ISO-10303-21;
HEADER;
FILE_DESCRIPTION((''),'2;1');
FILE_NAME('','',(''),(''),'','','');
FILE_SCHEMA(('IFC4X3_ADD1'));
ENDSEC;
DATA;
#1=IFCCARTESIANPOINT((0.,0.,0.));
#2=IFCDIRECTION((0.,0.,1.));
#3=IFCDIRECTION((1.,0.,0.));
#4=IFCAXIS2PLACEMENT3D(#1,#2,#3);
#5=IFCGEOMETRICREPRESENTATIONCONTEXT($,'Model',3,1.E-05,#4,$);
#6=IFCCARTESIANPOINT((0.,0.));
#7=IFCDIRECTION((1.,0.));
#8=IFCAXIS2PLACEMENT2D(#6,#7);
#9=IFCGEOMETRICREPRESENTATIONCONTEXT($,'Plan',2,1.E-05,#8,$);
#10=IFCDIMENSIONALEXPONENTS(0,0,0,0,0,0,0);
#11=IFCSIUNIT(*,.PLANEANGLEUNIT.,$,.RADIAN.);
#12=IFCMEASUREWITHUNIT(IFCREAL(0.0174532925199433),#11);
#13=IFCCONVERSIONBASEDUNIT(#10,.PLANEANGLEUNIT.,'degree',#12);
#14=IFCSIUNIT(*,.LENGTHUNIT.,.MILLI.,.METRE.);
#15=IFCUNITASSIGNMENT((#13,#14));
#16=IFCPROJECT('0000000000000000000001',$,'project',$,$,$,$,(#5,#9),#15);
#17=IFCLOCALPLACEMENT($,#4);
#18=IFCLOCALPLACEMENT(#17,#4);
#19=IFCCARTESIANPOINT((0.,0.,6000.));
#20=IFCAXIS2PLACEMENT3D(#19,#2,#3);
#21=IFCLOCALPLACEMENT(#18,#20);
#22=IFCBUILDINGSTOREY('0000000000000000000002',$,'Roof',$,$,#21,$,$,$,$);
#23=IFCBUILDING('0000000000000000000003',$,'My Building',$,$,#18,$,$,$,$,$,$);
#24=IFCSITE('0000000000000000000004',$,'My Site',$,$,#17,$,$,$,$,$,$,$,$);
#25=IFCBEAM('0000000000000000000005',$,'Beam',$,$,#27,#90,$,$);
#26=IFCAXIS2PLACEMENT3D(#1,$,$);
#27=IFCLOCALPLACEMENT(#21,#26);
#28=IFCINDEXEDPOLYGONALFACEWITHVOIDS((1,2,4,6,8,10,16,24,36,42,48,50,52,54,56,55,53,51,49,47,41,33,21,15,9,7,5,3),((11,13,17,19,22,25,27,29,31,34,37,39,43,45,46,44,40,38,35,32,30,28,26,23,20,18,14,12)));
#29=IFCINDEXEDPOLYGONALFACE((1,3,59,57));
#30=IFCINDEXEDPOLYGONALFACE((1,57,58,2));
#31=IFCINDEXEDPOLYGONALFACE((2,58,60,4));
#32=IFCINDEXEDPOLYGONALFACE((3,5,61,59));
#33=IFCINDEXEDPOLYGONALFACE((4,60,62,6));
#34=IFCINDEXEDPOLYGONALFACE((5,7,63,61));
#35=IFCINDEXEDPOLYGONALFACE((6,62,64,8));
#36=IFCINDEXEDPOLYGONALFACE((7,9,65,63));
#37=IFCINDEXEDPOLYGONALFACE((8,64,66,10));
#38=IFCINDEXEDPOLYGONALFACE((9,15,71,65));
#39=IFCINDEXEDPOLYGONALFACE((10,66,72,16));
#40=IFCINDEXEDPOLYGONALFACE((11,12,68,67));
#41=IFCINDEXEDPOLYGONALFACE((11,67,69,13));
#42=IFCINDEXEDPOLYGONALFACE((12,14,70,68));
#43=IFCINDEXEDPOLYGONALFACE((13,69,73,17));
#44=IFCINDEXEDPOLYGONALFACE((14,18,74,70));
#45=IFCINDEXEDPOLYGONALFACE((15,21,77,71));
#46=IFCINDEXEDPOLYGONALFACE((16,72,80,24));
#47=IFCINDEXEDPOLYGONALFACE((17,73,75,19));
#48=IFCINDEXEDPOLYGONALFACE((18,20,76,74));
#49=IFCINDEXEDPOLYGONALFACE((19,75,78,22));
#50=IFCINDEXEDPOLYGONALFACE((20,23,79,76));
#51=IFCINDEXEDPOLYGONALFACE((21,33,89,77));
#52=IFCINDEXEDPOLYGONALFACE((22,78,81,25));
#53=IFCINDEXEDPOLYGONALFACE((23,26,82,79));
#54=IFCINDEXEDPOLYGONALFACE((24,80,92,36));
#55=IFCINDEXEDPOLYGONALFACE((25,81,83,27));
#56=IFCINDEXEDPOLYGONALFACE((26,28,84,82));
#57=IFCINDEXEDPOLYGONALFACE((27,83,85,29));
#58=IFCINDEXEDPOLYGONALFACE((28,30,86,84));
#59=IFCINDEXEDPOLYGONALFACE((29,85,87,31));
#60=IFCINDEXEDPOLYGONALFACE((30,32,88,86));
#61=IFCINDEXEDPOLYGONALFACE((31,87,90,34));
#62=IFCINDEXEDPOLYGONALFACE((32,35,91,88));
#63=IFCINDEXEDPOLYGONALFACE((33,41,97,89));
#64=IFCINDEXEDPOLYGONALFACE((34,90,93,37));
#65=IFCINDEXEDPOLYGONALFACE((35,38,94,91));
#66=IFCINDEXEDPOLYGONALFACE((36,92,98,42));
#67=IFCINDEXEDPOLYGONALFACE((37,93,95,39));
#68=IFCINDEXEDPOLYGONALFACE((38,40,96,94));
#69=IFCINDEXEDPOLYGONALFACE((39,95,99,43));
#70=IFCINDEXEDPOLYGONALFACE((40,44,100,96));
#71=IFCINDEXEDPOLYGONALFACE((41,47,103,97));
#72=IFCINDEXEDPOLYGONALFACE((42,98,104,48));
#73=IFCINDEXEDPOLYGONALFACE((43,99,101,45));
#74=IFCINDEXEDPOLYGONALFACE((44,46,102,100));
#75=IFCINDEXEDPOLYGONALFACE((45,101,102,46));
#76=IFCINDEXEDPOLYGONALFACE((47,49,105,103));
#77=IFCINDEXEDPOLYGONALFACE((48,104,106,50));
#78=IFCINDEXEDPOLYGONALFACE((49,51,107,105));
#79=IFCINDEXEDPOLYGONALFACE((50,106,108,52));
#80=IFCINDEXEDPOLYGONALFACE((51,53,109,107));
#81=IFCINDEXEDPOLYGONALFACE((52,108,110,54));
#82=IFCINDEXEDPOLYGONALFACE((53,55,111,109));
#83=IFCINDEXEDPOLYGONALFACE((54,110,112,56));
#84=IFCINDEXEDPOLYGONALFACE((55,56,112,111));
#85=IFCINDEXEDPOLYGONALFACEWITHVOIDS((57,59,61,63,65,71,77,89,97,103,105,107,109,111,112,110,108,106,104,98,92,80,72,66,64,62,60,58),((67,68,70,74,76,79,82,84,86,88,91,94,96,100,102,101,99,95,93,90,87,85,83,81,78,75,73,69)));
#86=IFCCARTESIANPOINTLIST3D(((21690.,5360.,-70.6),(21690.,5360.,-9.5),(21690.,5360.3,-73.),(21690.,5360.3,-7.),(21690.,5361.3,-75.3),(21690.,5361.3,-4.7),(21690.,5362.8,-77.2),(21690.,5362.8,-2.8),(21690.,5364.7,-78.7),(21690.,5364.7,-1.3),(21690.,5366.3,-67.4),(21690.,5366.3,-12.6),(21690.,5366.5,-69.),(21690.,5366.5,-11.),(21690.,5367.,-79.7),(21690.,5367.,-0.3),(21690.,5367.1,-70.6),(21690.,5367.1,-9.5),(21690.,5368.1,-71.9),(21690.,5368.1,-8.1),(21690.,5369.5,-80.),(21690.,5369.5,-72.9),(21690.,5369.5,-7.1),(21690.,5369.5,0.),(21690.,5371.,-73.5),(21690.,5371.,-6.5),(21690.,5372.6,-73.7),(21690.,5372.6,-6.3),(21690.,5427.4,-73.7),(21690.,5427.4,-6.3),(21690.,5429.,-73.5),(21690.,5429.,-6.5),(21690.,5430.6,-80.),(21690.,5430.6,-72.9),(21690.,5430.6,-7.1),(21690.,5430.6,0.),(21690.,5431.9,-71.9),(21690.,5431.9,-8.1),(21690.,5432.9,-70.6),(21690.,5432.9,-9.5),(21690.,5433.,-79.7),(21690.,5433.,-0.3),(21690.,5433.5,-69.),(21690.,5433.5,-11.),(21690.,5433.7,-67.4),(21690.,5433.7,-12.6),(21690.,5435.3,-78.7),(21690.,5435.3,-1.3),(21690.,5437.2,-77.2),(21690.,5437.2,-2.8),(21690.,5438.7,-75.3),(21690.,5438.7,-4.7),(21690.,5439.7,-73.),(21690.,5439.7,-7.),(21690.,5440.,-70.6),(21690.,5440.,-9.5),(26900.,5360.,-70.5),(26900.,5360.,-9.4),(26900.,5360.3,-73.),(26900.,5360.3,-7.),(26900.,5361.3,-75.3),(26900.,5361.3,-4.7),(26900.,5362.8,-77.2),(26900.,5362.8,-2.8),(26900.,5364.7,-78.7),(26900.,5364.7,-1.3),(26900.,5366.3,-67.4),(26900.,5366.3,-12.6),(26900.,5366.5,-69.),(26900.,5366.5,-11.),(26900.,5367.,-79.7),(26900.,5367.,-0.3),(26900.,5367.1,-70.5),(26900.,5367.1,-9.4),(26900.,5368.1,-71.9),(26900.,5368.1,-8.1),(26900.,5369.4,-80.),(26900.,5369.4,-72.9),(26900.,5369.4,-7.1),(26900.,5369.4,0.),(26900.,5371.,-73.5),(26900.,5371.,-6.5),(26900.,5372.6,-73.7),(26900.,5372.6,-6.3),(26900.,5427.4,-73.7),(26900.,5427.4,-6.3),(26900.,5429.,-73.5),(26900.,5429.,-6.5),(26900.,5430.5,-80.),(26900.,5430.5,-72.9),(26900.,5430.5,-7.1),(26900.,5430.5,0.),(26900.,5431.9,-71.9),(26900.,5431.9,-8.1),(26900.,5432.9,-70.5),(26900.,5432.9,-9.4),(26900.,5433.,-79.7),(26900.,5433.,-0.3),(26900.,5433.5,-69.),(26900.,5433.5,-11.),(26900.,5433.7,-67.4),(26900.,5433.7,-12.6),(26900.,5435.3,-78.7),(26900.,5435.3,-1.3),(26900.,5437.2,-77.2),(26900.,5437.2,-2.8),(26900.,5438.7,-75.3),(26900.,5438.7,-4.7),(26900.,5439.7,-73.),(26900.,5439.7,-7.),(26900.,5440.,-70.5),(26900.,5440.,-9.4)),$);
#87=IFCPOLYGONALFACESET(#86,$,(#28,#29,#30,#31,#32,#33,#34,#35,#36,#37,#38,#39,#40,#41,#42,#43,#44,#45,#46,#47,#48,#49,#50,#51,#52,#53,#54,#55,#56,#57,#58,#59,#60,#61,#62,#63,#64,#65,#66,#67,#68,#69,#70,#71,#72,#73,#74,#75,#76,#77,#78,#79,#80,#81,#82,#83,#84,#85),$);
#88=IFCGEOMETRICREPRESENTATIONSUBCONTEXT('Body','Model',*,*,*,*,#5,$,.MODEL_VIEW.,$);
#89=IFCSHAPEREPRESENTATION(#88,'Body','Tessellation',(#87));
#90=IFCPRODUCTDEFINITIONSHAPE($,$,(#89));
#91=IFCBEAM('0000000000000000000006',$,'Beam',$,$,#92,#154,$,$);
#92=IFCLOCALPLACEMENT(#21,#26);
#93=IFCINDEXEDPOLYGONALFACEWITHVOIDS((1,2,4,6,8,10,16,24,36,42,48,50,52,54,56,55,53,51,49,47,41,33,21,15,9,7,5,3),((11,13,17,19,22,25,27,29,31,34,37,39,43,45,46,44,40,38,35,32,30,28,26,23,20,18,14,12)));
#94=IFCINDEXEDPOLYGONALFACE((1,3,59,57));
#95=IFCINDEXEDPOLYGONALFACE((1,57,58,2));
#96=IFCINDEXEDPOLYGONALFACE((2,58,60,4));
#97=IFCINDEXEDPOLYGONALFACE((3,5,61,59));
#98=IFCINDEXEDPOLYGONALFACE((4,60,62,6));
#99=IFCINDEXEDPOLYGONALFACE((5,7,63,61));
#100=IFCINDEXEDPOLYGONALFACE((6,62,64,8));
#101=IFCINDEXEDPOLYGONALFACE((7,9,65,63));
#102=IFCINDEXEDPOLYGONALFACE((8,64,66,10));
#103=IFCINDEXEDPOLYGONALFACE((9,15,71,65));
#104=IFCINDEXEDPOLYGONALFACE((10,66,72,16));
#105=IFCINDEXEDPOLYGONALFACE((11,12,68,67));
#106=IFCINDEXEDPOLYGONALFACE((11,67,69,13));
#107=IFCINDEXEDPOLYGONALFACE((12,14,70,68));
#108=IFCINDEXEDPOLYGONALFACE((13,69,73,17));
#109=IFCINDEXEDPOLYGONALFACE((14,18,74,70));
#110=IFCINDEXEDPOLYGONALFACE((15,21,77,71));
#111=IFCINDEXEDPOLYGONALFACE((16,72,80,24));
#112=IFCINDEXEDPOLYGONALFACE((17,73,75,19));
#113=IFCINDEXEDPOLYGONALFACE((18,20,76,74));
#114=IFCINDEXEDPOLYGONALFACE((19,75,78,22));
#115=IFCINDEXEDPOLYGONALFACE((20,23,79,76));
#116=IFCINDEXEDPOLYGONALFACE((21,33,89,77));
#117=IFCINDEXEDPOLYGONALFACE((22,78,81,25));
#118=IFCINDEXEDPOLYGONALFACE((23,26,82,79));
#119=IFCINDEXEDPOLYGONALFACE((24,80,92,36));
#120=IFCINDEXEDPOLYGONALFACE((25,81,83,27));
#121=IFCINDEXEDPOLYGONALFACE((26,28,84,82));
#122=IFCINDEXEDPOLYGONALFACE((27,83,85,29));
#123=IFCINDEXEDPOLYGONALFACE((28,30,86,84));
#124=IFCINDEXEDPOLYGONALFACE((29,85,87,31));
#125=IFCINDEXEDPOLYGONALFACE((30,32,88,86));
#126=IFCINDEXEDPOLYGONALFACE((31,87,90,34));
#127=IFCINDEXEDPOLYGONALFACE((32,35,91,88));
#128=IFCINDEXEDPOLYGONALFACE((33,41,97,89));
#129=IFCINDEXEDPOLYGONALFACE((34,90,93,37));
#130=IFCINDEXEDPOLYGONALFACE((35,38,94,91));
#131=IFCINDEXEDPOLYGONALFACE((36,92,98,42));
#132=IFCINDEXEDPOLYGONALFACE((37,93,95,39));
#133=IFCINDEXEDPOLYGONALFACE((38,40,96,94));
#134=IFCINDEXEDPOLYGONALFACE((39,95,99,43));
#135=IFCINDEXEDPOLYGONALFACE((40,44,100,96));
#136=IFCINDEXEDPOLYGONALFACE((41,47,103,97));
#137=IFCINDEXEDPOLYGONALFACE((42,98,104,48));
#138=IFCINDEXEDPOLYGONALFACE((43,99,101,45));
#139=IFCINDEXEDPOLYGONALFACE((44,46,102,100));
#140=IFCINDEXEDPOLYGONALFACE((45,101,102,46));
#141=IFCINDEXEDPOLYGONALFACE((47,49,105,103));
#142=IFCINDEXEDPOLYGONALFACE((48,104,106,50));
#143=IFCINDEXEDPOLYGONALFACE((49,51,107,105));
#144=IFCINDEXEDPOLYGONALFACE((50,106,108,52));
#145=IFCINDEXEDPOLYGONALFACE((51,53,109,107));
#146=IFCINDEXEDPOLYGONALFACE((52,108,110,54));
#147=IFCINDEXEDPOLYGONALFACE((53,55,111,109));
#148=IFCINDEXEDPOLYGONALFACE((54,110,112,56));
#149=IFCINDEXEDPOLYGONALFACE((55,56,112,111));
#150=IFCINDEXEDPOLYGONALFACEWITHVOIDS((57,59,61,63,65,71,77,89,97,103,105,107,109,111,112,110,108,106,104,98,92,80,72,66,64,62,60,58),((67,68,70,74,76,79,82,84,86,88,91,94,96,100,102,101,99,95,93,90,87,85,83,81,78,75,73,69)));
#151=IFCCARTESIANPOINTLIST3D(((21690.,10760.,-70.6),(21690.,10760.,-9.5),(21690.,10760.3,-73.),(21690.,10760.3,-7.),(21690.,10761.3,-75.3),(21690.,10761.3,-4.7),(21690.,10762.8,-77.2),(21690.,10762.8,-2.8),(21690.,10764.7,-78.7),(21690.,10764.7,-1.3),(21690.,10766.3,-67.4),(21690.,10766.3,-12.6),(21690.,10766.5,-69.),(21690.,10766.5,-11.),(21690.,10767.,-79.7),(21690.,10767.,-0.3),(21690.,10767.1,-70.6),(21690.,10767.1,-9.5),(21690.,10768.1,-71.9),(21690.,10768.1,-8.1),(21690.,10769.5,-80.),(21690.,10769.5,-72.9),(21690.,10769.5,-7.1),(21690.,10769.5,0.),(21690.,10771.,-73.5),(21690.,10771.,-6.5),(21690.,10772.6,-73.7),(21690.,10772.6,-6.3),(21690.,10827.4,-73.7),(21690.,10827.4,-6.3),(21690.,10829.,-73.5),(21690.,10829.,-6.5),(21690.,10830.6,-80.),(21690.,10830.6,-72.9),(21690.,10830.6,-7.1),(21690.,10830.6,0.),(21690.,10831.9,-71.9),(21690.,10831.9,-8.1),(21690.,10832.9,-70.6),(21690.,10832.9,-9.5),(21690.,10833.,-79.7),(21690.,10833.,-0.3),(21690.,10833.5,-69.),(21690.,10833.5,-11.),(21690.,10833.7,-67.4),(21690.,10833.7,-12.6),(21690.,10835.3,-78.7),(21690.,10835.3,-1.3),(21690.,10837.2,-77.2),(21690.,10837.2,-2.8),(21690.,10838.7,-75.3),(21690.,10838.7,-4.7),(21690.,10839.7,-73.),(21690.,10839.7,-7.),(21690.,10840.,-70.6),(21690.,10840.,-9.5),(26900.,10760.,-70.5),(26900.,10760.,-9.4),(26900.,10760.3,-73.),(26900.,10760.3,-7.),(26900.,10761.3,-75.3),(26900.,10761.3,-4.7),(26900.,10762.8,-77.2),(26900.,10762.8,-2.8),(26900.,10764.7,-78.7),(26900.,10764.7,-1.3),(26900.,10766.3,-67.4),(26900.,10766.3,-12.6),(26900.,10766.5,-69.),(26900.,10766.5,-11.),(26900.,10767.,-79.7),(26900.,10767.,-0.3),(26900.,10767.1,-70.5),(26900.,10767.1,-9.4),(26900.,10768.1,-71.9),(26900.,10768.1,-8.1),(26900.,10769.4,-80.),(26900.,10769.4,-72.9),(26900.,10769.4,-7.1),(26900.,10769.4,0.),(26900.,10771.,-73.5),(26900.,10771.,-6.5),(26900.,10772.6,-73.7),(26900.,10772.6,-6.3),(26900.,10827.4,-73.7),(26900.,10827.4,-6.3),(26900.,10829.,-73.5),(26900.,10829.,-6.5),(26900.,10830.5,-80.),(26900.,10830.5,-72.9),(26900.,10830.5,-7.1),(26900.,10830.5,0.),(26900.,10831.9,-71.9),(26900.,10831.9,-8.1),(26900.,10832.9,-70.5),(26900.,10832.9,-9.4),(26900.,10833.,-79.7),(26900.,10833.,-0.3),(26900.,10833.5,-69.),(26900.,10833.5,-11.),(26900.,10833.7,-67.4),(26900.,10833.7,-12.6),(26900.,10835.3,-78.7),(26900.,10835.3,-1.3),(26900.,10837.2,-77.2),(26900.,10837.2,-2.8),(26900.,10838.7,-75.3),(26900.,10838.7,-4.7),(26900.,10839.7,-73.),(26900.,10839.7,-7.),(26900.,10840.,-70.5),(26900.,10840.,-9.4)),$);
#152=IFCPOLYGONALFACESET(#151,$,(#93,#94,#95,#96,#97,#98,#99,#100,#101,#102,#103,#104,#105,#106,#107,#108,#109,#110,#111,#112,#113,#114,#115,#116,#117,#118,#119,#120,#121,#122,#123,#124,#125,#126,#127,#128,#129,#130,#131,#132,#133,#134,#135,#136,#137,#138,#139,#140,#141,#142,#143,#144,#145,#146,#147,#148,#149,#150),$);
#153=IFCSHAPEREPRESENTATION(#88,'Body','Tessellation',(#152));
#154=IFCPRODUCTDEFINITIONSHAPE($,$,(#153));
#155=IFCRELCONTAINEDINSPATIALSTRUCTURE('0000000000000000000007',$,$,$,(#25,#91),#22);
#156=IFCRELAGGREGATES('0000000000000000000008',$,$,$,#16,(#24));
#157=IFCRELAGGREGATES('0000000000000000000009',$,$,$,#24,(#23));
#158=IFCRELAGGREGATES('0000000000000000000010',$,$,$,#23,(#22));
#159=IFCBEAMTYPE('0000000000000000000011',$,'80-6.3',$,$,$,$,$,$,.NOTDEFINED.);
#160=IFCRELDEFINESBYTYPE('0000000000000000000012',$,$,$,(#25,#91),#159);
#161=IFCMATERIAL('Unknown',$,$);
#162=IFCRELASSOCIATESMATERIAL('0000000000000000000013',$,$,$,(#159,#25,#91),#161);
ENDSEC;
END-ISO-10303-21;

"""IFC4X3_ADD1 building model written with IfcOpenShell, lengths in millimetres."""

from ifc_helpers import new_model, entity, si_unit, converted_unit, frame, origin_with_axes, origin_2d_with_axis, place, context, subcontext, project, spatial, hollow_rectangle, extrude, material, material_profile, profile_set, profile_usage, type_object, element, save


model = new_model("IFC4X3_ADD1")

# Units and contexts
model_context = context("Model", 3, precision=1e-05, world=origin_with_axes())
plan_context = context("Plan", 2, precision=1e-05, world=origin_2d_with_axis())
body_context = subcontext(model_context, "Body", "Model", "MODEL_VIEW")
ifc_project = project(units=[converted_unit("PLANEANGLEUNIT", "degree", entity("IfcReal", 0.0174532925199433), si_unit("PLANEANGLEUNIT", "RADIAN"), dimensions=[0, 0, 0, 0, 0, 0, 0]), si_unit("LENGTHUNIT", "METRE", prefix="MILLI")], contexts=[model_context, plan_context])

# Site, building, storey
site_placement = place(None, origin_with_axes())
site = spatial("IfcSite", under=ifc_project, at=site_placement, Name="My Site")
building_placement = place(site_placement, origin_with_axes())
building = spatial("IfcBuilding", under=site, at=building_placement, Name="My Building")
storey_placement = place(building_placement, frame((0.0, 0.0, 6000.0), z_axis=(0.0, 0.0, 1.0), x_axis=(1.0, 0.0, 0.0)))
storey = spatial("IfcBuildingStorey", under=building, at=storey_placement, Name="Roof")

# Beams
ifc_material = material(Name="Unknown")
ifc_material_profile_1 = material_profile(ifc_material, hollow_rectangle(XDim=80.0, YDim=80.0, WallThickness=6.3, InnerFilletRadius=6.3, OuterFilletRadius=9.4))
ifc_profile_set_1 = profile_set([ifc_material_profile_1])
ifc_profile_usage_1 = profile_usage(ifc_profile_set_1, cardinal=8)
beam_type_1 = type_object("IfcBeamType", Name="80-6.3", PredefinedType="NOTDEFINED", material=ifc_profile_set_1)
beam_1_placement = place(storey_placement, frame((21690.0, 5400.0, 0.0), z_axis=(1.0, 0.0, 0.0), x_axis=(0.0, 1.0, 0.0)))
element("IfcBeam", 1, at=beam_1_placement, inside=storey, type_object=beam_type_1, material=ifc_profile_usage_1, Name="Beam", context=body_context, shape_type="SweptSolid", body=[
    extrude(hollow_rectangle(XDim=80.0, YDim=80.0, WallThickness=6.3, InnerFilletRadius=6.3, OuterFilletRadius=9.4), frame((0.0, -40.0, 0.0), z_axis=(0.0, 0.0, 1.0), x_axis=(1.0, 0.0, 0.0)), (0.0, 0.0, 1.0), 5210.0),
])
ifc_profile_usage_2 = profile_usage(ifc_profile_set_1, cardinal=8)
beam_2_placement = place(storey_placement, frame((21690.0, 10800.0, 0.0), z_axis=(1.0, 0.0, 0.0), x_axis=(0.0, 1.0, 0.0)))
element("IfcBeam", 2, at=beam_2_placement, inside=storey, type_object=beam_type_1, material=ifc_profile_usage_2, Name="Beam", context=body_context, shape_type="SweptSolid", body=[
    extrude(hollow_rectangle(XDim=80.0, YDim=80.0, WallThickness=6.3, InnerFilletRadius=6.3, OuterFilletRadius=9.4), frame((0.0, -40.0, 0.0), z_axis=(0.0, 0.0, 1.0), x_axis=(1.0, 0.0, 0.0)), (0.0, 0.0, 1.0), 5210.0),
])

save(model, "model.ifc")
